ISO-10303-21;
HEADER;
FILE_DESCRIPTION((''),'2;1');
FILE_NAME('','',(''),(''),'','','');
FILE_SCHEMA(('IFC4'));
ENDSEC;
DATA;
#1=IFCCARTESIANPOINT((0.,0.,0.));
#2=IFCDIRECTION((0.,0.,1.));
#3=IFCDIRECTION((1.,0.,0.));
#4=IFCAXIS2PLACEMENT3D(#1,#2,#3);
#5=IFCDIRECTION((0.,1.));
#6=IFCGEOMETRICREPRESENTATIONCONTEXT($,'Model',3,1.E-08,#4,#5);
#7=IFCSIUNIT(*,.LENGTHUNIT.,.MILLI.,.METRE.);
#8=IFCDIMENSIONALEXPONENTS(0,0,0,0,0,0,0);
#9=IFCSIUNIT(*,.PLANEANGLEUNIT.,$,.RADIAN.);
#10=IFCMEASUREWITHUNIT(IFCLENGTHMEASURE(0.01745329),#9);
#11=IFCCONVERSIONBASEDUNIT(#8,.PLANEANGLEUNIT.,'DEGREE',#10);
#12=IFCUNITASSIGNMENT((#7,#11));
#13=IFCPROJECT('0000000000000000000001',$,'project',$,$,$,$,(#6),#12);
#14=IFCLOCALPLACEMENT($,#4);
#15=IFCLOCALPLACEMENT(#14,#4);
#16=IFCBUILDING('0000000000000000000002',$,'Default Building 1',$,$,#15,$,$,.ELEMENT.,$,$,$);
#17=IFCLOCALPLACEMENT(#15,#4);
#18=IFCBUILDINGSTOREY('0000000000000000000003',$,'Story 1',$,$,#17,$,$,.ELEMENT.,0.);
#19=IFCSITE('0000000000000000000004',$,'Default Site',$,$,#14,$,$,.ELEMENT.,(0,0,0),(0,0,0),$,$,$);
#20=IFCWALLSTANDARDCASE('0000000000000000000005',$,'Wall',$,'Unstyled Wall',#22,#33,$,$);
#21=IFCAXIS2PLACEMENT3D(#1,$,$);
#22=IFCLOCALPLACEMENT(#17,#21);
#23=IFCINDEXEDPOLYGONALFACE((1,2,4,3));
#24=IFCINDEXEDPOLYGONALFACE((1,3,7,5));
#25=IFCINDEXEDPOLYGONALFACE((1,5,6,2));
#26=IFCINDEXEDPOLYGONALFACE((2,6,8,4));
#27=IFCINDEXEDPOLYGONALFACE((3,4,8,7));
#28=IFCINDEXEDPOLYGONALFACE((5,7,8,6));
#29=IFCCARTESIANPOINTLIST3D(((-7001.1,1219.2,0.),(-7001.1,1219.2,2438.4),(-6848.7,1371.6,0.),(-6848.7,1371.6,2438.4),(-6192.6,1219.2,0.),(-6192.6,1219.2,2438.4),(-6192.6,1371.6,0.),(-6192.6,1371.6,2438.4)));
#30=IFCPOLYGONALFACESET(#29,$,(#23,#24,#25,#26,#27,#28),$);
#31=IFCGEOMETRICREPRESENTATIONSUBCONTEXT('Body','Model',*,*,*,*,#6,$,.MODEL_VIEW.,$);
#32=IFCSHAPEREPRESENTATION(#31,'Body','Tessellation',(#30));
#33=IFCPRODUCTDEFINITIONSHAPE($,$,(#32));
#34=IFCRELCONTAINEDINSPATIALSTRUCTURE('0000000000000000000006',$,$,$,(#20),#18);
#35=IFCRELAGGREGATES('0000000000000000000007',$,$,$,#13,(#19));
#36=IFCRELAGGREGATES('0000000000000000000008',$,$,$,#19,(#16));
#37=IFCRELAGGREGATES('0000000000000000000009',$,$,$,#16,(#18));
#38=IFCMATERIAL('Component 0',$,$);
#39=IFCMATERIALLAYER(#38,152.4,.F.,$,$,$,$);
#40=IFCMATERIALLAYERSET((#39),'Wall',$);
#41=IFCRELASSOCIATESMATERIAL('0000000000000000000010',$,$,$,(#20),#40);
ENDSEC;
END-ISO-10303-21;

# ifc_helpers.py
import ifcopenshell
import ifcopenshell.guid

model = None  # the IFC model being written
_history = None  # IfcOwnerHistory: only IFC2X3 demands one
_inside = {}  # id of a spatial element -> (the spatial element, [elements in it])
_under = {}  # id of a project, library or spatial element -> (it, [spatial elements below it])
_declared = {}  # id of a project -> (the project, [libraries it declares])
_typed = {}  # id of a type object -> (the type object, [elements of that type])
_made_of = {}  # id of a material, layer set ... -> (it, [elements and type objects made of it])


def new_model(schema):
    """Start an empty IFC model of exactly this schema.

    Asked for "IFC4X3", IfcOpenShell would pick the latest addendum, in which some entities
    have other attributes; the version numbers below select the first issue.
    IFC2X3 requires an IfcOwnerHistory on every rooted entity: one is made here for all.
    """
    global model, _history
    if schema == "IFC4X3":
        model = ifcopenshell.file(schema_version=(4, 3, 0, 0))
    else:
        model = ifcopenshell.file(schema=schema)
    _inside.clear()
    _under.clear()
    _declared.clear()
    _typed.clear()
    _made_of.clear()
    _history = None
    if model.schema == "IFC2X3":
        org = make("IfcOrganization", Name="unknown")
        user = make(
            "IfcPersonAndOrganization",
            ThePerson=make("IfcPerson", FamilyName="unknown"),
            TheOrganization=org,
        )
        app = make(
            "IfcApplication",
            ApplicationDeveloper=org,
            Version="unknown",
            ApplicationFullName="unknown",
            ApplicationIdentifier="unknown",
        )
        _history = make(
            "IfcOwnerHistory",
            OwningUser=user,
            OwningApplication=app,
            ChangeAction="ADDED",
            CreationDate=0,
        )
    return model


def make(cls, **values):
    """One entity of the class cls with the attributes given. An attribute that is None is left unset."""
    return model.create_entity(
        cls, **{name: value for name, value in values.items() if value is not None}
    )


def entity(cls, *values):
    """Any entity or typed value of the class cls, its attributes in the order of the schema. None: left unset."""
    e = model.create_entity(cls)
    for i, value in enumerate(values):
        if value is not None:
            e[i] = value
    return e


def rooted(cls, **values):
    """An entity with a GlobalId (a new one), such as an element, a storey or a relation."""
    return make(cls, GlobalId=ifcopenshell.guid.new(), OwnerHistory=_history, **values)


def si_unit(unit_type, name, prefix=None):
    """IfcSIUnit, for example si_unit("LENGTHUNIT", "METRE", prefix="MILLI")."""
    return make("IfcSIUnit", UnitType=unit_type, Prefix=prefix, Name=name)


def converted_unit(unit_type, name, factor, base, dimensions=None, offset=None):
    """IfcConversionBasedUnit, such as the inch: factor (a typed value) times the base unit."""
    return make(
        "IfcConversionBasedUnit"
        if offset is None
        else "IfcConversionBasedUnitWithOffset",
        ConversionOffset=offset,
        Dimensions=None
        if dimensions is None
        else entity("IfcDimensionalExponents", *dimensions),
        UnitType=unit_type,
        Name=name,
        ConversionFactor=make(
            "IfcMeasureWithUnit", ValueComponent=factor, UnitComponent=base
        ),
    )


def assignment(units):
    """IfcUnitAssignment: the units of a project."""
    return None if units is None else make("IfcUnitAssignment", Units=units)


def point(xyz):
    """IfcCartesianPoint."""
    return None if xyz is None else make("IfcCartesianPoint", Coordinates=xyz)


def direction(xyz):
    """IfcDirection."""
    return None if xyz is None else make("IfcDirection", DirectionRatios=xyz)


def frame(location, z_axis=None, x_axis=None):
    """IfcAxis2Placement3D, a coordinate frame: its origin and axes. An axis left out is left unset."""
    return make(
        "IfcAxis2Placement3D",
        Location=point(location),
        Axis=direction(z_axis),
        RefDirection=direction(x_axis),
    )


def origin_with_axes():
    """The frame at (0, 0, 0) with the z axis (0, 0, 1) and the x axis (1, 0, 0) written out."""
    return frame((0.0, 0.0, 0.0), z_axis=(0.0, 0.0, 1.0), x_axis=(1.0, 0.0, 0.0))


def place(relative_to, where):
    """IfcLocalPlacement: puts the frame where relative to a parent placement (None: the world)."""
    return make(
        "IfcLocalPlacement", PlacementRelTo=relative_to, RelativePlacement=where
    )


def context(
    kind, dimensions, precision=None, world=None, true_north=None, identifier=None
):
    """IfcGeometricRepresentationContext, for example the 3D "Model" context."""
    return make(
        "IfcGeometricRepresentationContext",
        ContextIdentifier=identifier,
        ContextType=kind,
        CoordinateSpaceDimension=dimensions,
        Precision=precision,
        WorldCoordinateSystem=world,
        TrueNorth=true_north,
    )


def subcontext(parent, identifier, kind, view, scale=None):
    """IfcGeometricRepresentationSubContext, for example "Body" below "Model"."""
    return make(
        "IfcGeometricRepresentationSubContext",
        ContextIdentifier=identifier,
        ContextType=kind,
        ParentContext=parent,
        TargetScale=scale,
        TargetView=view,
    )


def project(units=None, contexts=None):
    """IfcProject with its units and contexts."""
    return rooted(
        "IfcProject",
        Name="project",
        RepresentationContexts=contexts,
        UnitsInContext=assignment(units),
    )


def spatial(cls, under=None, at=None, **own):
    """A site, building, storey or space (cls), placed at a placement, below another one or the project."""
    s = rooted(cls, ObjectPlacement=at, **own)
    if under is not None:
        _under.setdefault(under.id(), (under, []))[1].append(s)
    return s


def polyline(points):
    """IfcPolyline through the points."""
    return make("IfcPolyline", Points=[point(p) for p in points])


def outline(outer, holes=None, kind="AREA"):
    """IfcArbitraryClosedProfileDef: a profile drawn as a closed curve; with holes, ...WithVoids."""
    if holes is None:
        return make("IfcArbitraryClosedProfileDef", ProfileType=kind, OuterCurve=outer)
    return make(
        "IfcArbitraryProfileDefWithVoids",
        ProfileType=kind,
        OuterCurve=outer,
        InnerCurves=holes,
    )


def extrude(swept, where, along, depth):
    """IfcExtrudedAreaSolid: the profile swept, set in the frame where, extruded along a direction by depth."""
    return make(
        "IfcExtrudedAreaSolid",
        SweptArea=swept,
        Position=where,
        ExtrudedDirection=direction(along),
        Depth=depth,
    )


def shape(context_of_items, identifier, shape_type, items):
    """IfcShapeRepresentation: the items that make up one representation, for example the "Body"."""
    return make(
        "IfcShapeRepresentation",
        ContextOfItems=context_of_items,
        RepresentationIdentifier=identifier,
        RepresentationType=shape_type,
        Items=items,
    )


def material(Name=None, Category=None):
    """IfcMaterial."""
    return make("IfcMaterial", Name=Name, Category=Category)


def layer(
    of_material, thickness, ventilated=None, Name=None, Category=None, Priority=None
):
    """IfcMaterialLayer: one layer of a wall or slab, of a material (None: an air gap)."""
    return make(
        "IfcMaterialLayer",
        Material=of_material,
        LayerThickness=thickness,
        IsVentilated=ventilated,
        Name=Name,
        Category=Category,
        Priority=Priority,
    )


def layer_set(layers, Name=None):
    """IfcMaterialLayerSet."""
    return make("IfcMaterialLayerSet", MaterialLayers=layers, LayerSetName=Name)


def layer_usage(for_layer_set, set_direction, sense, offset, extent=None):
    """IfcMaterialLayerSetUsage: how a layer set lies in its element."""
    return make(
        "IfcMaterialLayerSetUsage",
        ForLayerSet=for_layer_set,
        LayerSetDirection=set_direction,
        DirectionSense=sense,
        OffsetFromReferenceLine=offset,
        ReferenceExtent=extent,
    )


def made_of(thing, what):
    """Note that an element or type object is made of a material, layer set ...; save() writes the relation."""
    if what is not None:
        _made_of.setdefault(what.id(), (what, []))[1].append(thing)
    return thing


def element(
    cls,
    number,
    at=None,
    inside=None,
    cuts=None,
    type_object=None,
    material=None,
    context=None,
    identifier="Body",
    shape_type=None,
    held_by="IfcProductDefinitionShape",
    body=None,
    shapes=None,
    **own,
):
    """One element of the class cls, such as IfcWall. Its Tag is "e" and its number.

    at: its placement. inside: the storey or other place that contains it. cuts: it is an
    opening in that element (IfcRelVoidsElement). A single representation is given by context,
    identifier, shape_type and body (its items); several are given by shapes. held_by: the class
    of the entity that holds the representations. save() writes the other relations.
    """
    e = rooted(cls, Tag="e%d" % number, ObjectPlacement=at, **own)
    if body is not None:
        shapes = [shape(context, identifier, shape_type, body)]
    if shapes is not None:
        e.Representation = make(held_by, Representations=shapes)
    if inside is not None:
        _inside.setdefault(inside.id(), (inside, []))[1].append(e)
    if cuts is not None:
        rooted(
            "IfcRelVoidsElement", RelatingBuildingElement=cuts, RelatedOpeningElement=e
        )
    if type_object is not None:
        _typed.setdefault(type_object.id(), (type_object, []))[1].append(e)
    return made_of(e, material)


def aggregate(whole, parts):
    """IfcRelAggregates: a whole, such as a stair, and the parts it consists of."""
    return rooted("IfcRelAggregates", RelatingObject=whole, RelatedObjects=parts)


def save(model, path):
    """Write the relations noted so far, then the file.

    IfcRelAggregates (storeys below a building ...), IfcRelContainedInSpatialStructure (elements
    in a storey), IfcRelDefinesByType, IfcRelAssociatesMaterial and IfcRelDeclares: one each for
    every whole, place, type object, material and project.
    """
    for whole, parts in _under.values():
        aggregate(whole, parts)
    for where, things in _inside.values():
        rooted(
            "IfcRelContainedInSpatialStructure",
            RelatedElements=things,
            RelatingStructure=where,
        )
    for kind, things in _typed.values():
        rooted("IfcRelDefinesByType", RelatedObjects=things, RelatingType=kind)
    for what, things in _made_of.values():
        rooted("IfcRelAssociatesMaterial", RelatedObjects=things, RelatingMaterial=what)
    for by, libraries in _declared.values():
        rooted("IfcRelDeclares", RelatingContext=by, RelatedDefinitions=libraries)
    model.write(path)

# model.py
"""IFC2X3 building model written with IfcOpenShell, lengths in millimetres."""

from ifc_helpers import new_model, entity, si_unit, converted_unit, direction, frame, origin_with_axes, place, context, subcontext, project, spatial, polyline, outline, extrude, material, layer, layer_set, layer_usage, element, save


model = new_model("IFC2X3")

# Units and contexts
model_context = context("Model", 3, precision=1e-08, world=origin_with_axes(), true_north=direction((0.0, 1.0)))
body_context = subcontext(model_context, "Body", "Model", "MODEL_VIEW")
ifc_project = project(units=[si_unit("LENGTHUNIT", "METRE", prefix="MILLI"), converted_unit("PLANEANGLEUNIT", "DEGREE", entity("IfcLengthMeasure", 0.01745329), si_unit("PLANEANGLEUNIT", "RADIAN"), dimensions=[0, 0, 0, 0, 0, 0, 0])], contexts=[model_context])

# Site, building, storey
site_placement = place(None, origin_with_axes())
site = spatial("IfcSite", under=ifc_project, at=site_placement, Name="Default Site", CompositionType="ELEMENT", RefLatitude=(0, 0, 0), RefLongitude=(0, 0, 0))
building_placement = place(site_placement, origin_with_axes())
building = spatial("IfcBuilding", under=site, at=building_placement, Name="Default Building 1", CompositionType="ELEMENT")
storey_placement = place(building_placement, origin_with_axes())
storey = spatial("IfcBuildingStorey", under=building, at=storey_placement, Name="Story 1", CompositionType="ELEMENT", Elevation=0.0)

# Wall
ifc_material_1 = material(Name="Component 0")
ifc_layer_1 = layer(ifc_material_1, 152.4, ventilated=False)
ifc_layer_set_1 = layer_set([ifc_layer_1], Name="Wall")
ifc_layer_usage_1 = layer_usage(ifc_layer_set_1, "AXIS2", "POSITIVE", -76.2)
wall_1_placement = place(storey_placement, frame((-6116.4, 1295.4, 0.0), z_axis=(0.0, 0.0, 1.0), x_axis=(-1.0, 0.0, 0.0)))
element("IfcWallStandardCase", 1, at=wall_1_placement, inside=storey, material=ifc_layer_usage_1, Name="Wall", ObjectType="Unstyled Wall", context=body_context, shape_type="SweptSolid", body=[
    extrude(outline(polyline([(76.2, 76.2), (76.2, -76.2), (732.3, -76.2), (884.7, 76.2), (76.2, 76.2)])), origin_with_axes(), (0.0, 0.0, 1.0), 2438.4),
])

save(model, "model.ifc")
